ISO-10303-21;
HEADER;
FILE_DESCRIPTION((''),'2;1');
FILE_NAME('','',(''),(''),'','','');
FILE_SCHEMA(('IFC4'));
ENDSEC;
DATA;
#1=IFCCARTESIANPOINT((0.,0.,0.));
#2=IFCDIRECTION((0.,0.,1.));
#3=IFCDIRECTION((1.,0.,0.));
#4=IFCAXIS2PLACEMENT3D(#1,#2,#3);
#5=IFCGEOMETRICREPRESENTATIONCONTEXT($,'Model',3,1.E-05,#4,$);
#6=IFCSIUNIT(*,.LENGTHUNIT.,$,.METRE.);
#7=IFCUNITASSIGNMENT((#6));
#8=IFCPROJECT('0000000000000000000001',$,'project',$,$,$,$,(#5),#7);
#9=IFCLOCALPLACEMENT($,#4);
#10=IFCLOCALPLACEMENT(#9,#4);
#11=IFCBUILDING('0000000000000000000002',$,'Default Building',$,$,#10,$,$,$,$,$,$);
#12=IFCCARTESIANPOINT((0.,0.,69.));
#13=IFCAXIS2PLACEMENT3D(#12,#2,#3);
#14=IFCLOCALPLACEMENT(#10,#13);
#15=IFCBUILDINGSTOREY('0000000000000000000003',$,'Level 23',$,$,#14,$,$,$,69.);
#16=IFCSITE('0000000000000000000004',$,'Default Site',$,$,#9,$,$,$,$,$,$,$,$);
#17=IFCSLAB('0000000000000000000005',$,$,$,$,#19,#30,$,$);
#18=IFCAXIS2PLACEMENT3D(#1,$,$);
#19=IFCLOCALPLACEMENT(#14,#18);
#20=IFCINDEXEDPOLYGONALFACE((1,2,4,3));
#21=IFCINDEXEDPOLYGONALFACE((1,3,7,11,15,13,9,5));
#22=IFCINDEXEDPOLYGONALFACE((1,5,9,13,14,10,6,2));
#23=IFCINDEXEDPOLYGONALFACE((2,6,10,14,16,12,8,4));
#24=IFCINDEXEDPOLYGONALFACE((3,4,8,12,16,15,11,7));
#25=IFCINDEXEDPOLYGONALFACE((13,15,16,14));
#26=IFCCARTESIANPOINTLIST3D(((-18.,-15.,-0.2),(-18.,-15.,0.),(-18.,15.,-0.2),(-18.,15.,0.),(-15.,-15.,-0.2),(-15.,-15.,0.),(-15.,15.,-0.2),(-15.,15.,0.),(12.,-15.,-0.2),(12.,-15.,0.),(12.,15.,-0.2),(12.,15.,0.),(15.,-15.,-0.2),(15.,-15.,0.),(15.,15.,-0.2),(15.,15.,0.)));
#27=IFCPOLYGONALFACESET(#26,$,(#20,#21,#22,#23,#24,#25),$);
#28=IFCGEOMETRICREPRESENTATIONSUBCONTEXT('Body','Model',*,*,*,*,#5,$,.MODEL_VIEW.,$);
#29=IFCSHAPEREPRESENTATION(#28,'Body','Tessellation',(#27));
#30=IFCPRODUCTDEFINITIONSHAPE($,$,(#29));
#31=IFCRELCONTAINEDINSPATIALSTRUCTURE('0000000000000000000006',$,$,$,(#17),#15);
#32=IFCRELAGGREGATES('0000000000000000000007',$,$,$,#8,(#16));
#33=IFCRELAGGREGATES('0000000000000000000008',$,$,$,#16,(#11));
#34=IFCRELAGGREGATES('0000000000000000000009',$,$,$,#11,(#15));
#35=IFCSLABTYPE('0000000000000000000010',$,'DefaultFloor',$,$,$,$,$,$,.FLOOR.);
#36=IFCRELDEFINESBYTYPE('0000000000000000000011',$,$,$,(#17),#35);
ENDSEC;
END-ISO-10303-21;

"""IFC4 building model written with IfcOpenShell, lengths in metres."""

from ifc_helpers import new_model, si_unit, frame, origin_with_axes, place, context, subcontext, project, spatial, polyline, outline, extrude, type_object, element, save


model = new_model("IFC4")

# Units and contexts
model_context = context("Model", 3, precision=1e-05, world=origin_with_axes())
body_context = subcontext(model_context, "Body", "Model", "MODEL_VIEW")
ifc_project = project(units=[si_unit("LENGTHUNIT", "METRE")], contexts=[model_context])

# Site, building, storey
site_placement = place(None, origin_with_axes())
site = spatial("IfcSite", under=ifc_project, at=site_placement, Name="Default Site")
building_placement = place(site_placement, origin_with_axes())
building = spatial("IfcBuilding", under=site, at=building_placement, Name="Default Building")
storey_placement = place(building_placement, frame((0.0, 0.0, 69.0), z_axis=(0.0, 0.0, 1.0), x_axis=(1.0, 0.0, 0.0)))
storey = spatial("IfcBuildingStorey", under=building, at=storey_placement, Name="Level 23", Elevation=69.0)

# Slab
slab_type = type_object("IfcSlabType", Name="DefaultFloor", PredefinedType="FLOOR")
slab_placement = place(storey_placement, frame((0.0, 0.0, -69.0), z_axis=(0.0, 0.0, 1.0), x_axis=(1.0, 0.0, 0.0)))
element("IfcSlab", 1, at=slab_placement, inside=storey, type_object=slab_type, context=body_context, shape_type="SweptSolid", body=[
    extrude(outline(polyline([(-18.0, 15.0), (-15.0, 15.0), (12.0, 15.0), (15.0, 15.0), (15.0, -15.0), (12.0, -15.0), (-15.0, -15.0), (-18.0, -15.0), (-18.0, 15.0)])), frame((0.0, 0.0, 69.0), z_axis=(0.0, 0.0, 1.0), x_axis=(1.0, 0.0, 0.0)), (0.0, 0.0, -1.0), 0.2),
])

save(model, "model.ifc")
